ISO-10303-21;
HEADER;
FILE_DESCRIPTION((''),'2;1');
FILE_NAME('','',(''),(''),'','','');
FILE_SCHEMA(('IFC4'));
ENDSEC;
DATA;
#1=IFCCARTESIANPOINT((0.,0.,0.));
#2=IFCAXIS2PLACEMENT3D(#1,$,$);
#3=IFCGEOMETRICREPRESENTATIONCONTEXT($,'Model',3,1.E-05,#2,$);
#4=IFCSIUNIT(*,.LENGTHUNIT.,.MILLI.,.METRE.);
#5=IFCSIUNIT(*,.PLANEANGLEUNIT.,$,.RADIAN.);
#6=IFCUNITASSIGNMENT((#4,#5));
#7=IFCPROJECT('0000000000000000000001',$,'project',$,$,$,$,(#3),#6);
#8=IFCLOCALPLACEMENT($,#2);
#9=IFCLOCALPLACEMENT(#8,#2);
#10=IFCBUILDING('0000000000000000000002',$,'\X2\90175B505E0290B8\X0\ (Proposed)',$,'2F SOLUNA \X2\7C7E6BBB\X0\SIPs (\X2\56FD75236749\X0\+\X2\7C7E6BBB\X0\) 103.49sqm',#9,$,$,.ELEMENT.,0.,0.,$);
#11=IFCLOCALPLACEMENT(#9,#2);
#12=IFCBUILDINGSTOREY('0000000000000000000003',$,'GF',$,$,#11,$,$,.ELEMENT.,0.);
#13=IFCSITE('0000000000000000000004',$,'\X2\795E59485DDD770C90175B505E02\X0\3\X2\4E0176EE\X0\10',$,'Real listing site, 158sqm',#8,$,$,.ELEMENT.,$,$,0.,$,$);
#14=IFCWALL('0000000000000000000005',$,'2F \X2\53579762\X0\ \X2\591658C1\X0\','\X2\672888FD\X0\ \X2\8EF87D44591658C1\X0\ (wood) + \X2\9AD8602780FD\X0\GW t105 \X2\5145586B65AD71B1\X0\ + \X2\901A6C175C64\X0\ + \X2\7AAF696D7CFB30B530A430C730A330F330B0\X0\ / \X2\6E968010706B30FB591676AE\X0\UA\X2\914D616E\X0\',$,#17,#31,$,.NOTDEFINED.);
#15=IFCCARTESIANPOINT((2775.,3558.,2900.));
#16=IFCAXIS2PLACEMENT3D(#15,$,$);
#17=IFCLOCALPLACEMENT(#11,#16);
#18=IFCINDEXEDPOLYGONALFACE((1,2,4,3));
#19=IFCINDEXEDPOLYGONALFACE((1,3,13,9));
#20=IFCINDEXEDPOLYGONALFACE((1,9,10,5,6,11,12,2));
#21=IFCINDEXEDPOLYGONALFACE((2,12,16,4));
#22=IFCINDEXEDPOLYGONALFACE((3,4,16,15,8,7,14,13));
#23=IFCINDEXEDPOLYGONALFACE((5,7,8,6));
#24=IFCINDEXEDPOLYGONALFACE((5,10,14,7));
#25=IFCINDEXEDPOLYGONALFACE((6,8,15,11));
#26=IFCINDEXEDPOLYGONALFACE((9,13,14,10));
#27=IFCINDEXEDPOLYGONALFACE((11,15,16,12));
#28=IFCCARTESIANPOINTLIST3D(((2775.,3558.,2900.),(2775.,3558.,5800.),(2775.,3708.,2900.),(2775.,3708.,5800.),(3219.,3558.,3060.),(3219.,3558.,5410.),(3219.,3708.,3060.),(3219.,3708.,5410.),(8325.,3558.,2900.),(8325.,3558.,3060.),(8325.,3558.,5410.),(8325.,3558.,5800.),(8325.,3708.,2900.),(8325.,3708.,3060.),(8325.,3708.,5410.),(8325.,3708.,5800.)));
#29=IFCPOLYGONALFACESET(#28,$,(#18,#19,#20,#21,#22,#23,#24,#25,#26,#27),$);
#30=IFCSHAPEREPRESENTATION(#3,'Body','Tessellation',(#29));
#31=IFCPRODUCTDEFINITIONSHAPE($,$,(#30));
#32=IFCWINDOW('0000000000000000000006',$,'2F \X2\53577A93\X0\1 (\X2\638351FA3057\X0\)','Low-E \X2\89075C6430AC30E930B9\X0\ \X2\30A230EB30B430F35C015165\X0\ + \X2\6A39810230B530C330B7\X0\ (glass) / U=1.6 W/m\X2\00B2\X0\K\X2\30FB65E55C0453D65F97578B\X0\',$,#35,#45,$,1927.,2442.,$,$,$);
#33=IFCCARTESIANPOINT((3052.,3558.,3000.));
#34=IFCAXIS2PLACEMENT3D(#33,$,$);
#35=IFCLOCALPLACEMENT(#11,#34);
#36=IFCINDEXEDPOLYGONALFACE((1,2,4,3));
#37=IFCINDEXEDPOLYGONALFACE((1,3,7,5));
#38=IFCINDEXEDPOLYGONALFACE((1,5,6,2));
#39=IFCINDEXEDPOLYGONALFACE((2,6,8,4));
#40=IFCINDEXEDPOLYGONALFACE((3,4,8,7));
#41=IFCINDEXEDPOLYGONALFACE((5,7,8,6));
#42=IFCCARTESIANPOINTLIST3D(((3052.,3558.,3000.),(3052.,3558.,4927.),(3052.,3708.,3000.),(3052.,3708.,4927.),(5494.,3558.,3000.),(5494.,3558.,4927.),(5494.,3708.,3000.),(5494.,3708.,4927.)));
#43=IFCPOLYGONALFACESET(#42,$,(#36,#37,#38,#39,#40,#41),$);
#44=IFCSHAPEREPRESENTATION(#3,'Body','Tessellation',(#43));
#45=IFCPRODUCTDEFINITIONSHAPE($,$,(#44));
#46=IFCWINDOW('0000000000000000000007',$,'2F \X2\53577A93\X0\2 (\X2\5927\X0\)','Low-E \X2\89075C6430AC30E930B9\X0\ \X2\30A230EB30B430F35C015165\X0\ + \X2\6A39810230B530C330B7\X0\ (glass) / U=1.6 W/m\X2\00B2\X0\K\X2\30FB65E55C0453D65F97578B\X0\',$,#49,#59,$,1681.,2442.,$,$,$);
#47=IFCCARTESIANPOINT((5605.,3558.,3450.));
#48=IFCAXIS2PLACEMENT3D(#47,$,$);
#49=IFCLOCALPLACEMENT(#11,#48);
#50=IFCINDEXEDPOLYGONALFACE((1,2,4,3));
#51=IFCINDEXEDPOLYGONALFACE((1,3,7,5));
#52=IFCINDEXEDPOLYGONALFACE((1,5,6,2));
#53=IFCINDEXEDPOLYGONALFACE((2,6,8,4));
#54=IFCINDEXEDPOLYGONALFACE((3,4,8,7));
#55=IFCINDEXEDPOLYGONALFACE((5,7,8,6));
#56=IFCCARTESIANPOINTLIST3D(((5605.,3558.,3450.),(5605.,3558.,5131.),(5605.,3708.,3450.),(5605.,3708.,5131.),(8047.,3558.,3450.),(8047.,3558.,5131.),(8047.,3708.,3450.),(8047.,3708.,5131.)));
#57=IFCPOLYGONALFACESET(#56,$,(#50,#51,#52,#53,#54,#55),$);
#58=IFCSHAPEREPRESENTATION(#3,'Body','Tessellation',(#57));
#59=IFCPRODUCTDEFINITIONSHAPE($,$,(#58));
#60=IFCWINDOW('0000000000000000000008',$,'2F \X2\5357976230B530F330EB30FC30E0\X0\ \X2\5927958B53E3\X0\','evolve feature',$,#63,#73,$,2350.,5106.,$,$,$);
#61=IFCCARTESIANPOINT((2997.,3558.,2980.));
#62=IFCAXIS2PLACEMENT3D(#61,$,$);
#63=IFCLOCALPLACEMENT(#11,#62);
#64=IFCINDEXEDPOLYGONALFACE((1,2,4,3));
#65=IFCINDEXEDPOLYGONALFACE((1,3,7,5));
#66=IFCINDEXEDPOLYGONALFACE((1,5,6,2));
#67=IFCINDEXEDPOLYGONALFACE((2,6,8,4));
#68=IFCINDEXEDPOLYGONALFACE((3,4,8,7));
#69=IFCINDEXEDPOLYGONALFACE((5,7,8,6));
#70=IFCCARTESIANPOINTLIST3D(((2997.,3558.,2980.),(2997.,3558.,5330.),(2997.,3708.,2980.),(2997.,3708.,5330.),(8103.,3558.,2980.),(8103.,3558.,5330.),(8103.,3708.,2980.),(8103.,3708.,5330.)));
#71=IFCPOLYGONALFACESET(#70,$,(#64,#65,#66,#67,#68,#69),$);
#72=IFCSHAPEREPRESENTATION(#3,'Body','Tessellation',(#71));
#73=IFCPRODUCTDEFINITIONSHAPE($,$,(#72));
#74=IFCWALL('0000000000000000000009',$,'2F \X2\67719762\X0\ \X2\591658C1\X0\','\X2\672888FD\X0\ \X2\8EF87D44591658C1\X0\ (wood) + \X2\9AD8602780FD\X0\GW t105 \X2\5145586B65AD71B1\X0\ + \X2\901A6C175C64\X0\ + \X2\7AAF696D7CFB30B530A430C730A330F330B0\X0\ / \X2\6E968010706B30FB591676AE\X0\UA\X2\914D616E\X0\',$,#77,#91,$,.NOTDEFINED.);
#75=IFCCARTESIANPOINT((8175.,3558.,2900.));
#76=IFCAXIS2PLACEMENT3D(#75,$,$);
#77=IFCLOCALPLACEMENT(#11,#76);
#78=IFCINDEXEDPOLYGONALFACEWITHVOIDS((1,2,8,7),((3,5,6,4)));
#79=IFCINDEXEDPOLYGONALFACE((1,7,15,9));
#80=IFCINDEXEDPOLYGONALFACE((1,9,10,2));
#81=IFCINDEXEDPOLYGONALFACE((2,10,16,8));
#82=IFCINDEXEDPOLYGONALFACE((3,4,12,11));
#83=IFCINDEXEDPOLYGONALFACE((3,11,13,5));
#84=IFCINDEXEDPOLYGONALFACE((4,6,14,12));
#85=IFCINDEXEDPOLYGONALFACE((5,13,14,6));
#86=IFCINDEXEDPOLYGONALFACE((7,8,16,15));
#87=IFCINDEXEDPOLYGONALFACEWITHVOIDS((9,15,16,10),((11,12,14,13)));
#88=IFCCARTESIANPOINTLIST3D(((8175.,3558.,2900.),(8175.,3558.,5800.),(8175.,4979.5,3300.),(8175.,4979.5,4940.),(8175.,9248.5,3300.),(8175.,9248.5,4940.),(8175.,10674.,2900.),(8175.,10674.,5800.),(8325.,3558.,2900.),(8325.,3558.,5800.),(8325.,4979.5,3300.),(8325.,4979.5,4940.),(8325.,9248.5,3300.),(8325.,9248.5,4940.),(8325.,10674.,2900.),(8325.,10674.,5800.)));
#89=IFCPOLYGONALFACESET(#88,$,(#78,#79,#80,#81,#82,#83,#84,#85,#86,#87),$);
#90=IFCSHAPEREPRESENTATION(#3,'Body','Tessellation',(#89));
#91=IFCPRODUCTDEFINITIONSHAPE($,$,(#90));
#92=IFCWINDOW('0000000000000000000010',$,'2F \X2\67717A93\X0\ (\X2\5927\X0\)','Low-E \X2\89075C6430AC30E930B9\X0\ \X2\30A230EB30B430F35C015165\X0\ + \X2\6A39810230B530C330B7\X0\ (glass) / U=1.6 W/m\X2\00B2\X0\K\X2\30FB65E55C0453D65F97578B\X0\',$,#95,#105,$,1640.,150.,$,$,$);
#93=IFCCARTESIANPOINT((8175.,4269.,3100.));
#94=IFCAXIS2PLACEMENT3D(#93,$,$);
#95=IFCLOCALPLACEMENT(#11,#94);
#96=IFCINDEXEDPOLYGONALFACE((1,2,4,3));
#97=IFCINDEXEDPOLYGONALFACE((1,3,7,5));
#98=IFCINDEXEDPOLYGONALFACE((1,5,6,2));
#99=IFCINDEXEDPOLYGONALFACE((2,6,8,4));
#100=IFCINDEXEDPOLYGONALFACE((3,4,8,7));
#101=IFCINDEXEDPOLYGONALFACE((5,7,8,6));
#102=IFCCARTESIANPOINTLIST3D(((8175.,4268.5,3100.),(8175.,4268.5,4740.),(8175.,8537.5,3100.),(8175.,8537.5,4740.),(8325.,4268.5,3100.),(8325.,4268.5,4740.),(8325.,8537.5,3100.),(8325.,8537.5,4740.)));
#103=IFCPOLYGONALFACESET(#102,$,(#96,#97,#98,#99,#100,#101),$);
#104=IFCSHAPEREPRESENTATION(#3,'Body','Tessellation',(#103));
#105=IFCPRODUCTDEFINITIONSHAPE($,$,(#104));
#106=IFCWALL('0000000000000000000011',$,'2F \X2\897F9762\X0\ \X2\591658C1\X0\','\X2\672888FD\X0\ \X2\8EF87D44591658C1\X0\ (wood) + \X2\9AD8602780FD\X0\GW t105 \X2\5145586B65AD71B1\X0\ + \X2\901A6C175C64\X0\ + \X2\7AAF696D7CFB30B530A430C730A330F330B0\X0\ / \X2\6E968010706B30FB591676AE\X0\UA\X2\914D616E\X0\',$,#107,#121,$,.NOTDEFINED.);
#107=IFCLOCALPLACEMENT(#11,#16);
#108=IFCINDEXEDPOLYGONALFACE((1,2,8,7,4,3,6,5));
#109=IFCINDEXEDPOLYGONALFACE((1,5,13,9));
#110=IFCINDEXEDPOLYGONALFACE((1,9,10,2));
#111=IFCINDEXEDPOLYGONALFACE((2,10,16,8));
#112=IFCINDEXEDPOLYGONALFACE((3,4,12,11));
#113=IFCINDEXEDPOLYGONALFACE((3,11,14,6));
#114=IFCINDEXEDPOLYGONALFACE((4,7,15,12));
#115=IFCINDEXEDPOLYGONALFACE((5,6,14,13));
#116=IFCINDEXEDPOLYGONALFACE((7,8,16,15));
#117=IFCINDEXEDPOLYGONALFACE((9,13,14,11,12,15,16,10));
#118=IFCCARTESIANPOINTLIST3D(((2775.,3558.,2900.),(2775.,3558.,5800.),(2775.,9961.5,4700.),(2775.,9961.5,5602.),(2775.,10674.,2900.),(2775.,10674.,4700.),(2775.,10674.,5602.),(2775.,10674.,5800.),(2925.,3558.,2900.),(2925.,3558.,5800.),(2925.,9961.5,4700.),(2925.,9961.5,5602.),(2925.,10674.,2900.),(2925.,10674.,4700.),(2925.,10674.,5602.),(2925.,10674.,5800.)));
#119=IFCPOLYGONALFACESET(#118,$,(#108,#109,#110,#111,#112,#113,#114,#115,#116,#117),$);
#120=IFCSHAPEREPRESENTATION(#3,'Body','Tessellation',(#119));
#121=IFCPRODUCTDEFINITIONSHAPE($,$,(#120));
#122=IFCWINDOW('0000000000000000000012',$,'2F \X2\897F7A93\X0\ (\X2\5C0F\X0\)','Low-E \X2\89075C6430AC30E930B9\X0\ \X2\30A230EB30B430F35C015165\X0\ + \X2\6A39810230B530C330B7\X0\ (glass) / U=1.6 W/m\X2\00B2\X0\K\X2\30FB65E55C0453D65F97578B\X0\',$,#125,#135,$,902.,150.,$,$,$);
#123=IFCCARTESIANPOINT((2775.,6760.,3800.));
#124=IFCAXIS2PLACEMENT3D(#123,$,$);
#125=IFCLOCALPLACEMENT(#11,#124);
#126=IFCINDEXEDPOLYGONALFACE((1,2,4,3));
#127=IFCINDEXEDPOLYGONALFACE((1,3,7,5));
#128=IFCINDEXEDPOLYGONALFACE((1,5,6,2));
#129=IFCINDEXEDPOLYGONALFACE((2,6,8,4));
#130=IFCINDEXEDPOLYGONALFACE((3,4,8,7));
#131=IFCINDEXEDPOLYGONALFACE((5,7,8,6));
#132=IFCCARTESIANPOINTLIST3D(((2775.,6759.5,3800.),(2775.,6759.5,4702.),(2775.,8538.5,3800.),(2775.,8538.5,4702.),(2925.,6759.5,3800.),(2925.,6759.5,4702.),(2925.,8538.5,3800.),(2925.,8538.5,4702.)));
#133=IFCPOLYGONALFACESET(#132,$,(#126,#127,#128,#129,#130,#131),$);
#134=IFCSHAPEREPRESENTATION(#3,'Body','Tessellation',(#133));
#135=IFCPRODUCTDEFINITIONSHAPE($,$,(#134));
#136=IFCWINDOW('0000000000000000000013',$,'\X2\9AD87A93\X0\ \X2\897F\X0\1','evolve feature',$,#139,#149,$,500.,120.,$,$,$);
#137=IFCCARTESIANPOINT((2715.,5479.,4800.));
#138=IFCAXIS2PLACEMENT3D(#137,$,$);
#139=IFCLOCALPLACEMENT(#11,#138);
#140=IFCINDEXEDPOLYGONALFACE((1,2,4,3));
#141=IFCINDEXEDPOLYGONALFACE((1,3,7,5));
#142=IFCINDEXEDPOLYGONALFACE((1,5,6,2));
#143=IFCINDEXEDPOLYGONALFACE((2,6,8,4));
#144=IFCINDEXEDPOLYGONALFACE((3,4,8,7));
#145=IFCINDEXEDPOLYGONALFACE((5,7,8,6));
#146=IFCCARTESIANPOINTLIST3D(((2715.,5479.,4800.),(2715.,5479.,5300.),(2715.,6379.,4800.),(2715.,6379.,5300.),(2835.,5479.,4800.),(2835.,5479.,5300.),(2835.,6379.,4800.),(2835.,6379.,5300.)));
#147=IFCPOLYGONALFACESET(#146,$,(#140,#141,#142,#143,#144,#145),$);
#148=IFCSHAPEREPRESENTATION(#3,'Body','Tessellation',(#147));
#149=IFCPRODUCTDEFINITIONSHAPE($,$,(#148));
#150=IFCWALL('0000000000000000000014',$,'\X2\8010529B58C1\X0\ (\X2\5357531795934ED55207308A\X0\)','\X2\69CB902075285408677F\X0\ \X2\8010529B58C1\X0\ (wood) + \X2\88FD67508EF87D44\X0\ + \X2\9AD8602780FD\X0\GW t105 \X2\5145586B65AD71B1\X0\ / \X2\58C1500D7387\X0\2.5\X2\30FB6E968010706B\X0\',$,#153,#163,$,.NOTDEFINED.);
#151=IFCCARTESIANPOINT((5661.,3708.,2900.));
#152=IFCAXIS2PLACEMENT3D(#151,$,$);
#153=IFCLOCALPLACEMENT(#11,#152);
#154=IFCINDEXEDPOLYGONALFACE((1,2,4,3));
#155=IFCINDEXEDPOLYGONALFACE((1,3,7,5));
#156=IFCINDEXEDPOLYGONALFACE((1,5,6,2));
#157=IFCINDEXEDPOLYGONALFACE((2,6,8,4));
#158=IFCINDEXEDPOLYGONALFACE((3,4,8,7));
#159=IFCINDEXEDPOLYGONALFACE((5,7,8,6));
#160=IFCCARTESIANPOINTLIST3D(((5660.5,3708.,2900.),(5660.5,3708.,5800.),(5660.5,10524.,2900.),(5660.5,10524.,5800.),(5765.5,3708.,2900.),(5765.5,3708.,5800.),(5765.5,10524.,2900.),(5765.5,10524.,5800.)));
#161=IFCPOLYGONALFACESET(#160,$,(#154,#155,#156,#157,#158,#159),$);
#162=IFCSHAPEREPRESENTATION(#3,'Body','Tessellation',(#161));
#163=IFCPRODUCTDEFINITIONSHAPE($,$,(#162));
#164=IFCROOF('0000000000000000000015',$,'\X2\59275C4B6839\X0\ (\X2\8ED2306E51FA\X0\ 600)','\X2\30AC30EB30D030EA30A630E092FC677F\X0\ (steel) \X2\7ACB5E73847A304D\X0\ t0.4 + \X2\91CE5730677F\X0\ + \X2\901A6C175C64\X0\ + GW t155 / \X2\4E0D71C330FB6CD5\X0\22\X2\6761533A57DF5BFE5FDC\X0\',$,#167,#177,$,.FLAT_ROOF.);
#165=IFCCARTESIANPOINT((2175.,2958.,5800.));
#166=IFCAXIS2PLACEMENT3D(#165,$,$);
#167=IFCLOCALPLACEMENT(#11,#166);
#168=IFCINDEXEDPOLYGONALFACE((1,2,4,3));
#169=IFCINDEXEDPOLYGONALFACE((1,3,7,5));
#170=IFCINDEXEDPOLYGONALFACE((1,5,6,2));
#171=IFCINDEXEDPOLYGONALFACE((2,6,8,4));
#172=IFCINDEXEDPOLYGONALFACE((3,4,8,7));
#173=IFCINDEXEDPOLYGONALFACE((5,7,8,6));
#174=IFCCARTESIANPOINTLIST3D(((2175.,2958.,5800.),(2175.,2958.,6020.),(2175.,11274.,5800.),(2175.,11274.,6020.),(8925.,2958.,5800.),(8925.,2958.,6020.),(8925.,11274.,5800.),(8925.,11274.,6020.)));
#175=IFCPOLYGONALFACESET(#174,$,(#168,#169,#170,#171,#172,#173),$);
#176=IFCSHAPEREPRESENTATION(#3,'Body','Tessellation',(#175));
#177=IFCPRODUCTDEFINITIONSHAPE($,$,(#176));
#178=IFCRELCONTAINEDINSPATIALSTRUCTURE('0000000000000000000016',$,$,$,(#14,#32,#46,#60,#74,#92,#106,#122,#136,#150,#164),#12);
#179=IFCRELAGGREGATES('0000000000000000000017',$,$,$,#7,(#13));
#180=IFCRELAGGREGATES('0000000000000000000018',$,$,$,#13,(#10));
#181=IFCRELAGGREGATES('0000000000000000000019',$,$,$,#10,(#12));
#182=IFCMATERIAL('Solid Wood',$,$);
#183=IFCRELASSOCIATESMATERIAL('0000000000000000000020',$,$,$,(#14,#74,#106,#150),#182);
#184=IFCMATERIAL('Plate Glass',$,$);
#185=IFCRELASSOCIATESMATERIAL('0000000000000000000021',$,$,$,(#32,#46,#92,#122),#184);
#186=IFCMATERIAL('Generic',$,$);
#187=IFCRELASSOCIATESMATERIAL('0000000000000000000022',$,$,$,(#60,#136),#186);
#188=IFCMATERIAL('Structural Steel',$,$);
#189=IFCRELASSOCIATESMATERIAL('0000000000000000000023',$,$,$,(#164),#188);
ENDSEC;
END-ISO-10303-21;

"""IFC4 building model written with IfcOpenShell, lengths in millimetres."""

from ifc_helpers import new_model, si_unit, frame, frame_2d, origin, place, context, project, spatial, rectangle, extrude, material, element, fill, save


model = new_model("IFC4")

# Units and contexts
model_context = context("Model", 3, precision=1e-05, world=origin())
ifc_project = project(units=[si_unit("LENGTHUNIT", "METRE", prefix="MILLI"), si_unit("PLANEANGLEUNIT", "RADIAN")], contexts=[model_context])

# Site, building, storey
site_placement = place(None, origin())
site = spatial("IfcSite", under=ifc_project, at=site_placement, Name="神奈川県逗子市3丁目10", ObjectType="Real listing site, 158sqm", CompositionType="ELEMENT", RefElevation=0.0)
building_placement = place(site_placement, origin())
building = spatial("IfcBuilding", under=site, at=building_placement, Name="逗子市邸 (Proposed)", ObjectType="2F SOLUNA 籾殻SIPs (国産杉+籾殻) 103.49sqm", CompositionType="ELEMENT", ElevationOfRefHeight=0.0, ElevationOfTerrain=0.0)
storey_placement = place(building_placement, origin())
storey = spatial("IfcBuildingStorey", under=building, at=storey_placement, Name="GF", CompositionType="ELEMENT", Elevation=0.0)

# Shared definitions
ifc_material_1 = material(Name="Solid Wood")

# Wall, openings, windows
wall_1_placement = place(storey_placement, frame((2775.0, 3558.0, 2900.0)))
wall_1 = element("IfcWall", 1, at=wall_1_placement, inside=storey, material=ifc_material_1, Name="2F 南面 外壁", Description="木製 軸組外壁 (wood) + 高性能GW t105 充填断熱 + 通気層 + 窯業系サイディング / 準耐火・外皮UA配慮", PredefinedType="NOTDEFINED", context=model_context, shape_type="SweptSolid", body=[
    extrude(rectangle(XDim=5550.0, YDim=150.0, at=frame_2d((2775.0, 75.0))), frame((2775.0, 3558.0, 2900.0)), (0.0, 0.0, 1.0), 2900.0),
])
opening_1_placement = place(storey_placement, frame((3052.0, 3558.0, 3000.0)))
opening_1 = element("IfcOpeningElement", 2, at=opening_1_placement, cuts=wall_1, PredefinedType="NOTDEFINED", context=model_context, shape_type="SweptSolid", body=[
    extrude(rectangle(XDim=2442.0, YDim=150.0, at=frame_2d((1221.0, 75.0))), frame((3052.0, 3558.0, 3000.0)), (0.0, 0.0, 1.0), 1927.0),
])
opening_2_placement = place(storey_placement, frame((5605.0, 3558.0, 3450.0)))
opening_2 = element("IfcOpeningElement", 3, at=opening_2_placement, cuts=wall_1, PredefinedType="NOTDEFINED", context=model_context, shape_type="SweptSolid", body=[
    extrude(rectangle(XDim=2442.0, YDim=150.0, at=frame_2d((1221.0, 75.0))), frame((5605.0, 3558.0, 3450.0)), (0.0, 0.0, 1.0), 1681.0),
])
opening_3_placement = place(storey_placement, frame((2997.0, 3558.0, 2980.0)))
opening_3 = element("IfcOpeningElement", 4, at=opening_3_placement, cuts=wall_1, PredefinedType="NOTDEFINED", context=model_context, shape_type="SweptSolid", body=[
    extrude(rectangle(XDim=5106.0, YDim=150.0, at=frame_2d((2553.0, 75.0))), frame((2997.0, 3558.0, 2980.0)), (0.0, 0.0, 1.0), 2350.0),
])
ifc_material_2 = material(Name="Plate Glass")
window_1_placement = place(storey_placement, frame((3052.0, 3558.0, 3000.0)))
window_1 = element("IfcWindow", 5, at=window_1_placement, inside=storey, material=ifc_material_2, Name="2F 南窓1 (掃出し)", Description="Low-E 複層ガラス アルゴン封入 + 樹脂サッシ (glass) / U=1.6 W/m²K・日射取得型", OverallHeight=1927.0, OverallWidth=2442.0, context=model_context, shape_type="SweptSolid", body=[
    extrude(rectangle(XDim=2442.0, YDim=150.0, at=frame_2d((1221.0, 75.0))), frame((3052.0, 3558.0, 3000.0)), (0.0, 0.0, 1.0), 1927.0),
])
fill(opening_1, window_1)
window_2_placement = place(storey_placement, frame((5605.0, 3558.0, 3450.0)))
window_2 = element("IfcWindow", 6, at=window_2_placement, inside=storey, material=ifc_material_2, Name="2F 南窓2 (大)", Description="Low-E 複層ガラス アルゴン封入 + 樹脂サッシ (glass) / U=1.6 W/m²K・日射取得型", OverallHeight=1681.0, OverallWidth=2442.0, context=model_context, shape_type="SweptSolid", body=[
    extrude(rectangle(XDim=2442.0, YDim=150.0, at=frame_2d((1221.0, 75.0))), frame((5605.0, 3558.0, 3450.0)), (0.0, 0.0, 1.0), 1681.0),
])
fill(opening_2, window_2)
ifc_material_3 = material(Name="Generic")
window_3_placement = place(storey_placement, frame((2997.0, 3558.0, 2980.0)))
window_3 = element("IfcWindow", 7, at=window_3_placement, inside=storey, material=ifc_material_3, Name="2F 南面サンルーム 大開口", Description="evolve feature", OverallHeight=2350.0, OverallWidth=5106.0, context=model_context, shape_type="SweptSolid", body=[
    extrude(rectangle(XDim=5106.0, YDim=150.0, at=frame_2d((2553.0, 75.0))), frame((2997.0, 3558.0, 2980.0)), (0.0, 0.0, 1.0), 2350.0),
])
fill(opening_3, window_3)

# Wall, opening, window
wall_2_placement = place(storey_placement, frame((8175.0, 3558.0, 2900.0)))
wall_2 = element("IfcWall", 8, at=wall_2_placement, inside=storey, material=ifc_material_1, Name="2F 東面 外壁", Description="木製 軸組外壁 (wood) + 高性能GW t105 充填断熱 + 通気層 + 窯業系サイディング / 準耐火・外皮UA配慮", PredefinedType="NOTDEFINED", context=model_context, shape_type="SweptSolid", body=[
    extrude(rectangle(XDim=150.0, YDim=7116.0, at=frame_2d((75.0, 3558.0))), frame((8175.0, 3558.0, 2900.0)), (0.0, 0.0, 1.0), 2900.0),
])
opening_4_placement = place(storey_placement, frame((8175.0, 4269.0, 3100.0)))
opening_4 = element("IfcOpeningElement", 9, at=opening_4_placement, cuts=wall_2, PredefinedType="NOTDEFINED", context=model_context, shape_type="SweptSolid", body=[
    extrude(rectangle(XDim=150.0, YDim=4269.0, at=frame_2d((75.0, 2134.0))), frame((8175.0, 4269.0, 3100.0)), (0.0, 0.0, 1.0), 1640.0),
])
window_4_placement = place(storey_placement, frame((8175.0, 4269.0, 3100.0)))
window_4 = element("IfcWindow", 10, at=window_4_placement, inside=storey, material=ifc_material_2, Name="2F 東窓 (大)", Description="Low-E 複層ガラス アルゴン封入 + 樹脂サッシ (glass) / U=1.6 W/m²K・日射取得型", OverallHeight=1640.0, OverallWidth=150.0, context=model_context, shape_type="SweptSolid", body=[
    extrude(rectangle(XDim=150.0, YDim=4269.0, at=frame_2d((75.0, 2134.0))), frame((8175.0, 4269.0, 3100.0)), (0.0, 0.0, 1.0), 1640.0),
])
fill(opening_4, window_4)

# Wall, openings, windows
wall_3_placement = place(storey_placement, frame((2775.0, 3558.0, 2900.0)))
wall_3 = element("IfcWall", 11, at=wall_3_placement, inside=storey, material=ifc_material_1, Name="2F 西面 外壁", Description="木製 軸組外壁 (wood) + 高性能GW t105 充填断熱 + 通気層 + 窯業系サイディング / 準耐火・外皮UA配慮", PredefinedType="NOTDEFINED", context=model_context, shape_type="SweptSolid", body=[
    extrude(rectangle(XDim=150.0, YDim=7116.0, at=frame_2d((75.0, 3558.0))), frame((2775.0, 3558.0, 2900.0)), (0.0, 0.0, 1.0), 2900.0),
])
opening_5_placement = place(storey_placement, frame((2775.0, 6760.0, 3800.0)))
opening_5 = element("IfcOpeningElement", 12, at=opening_5_placement, cuts=wall_3, PredefinedType="NOTDEFINED", context=model_context, shape_type="SweptSolid", body=[
    extrude(rectangle(XDim=150.0, YDim=1779.0, at=frame_2d((75.0, 889.0))), frame((2775.0, 6760.0, 3800.0)), (0.0, 0.0, 1.0), 902.0),
])
opening_6_placement = place(storey_placement, frame((2715.0, 5479.0, 4800.0)))
opening_6 = element("IfcOpeningElement", 13, at=opening_6_placement, cuts=wall_3, PredefinedType="NOTDEFINED", context=model_context, shape_type="SweptSolid", body=[
    extrude(rectangle(XDim=120.0, YDim=900.0, at=frame_2d((60.0, 450.0))), frame((2715.0, 5479.0, 4800.0)), (0.0, 0.0, 1.0), 500.0),
])
window_5_placement = place(storey_placement, frame((2775.0, 6760.0, 3800.0)))
window_5 = element("IfcWindow", 14, at=window_5_placement, inside=storey, material=ifc_material_2, Name="2F 西窓 (小)", Description="Low-E 複層ガラス アルゴン封入 + 樹脂サッシ (glass) / U=1.6 W/m²K・日射取得型", OverallHeight=902.0, OverallWidth=150.0, context=model_context, shape_type="SweptSolid", body=[
    extrude(rectangle(XDim=150.0, YDim=1779.0, at=frame_2d((75.0, 889.0))), frame((2775.0, 6760.0, 3800.0)), (0.0, 0.0, 1.0), 902.0),
])
fill(opening_5, window_5)
window_6_placement = place(storey_placement, frame((2715.0, 5479.0, 4800.0)))
window_6 = element("IfcWindow", 15, at=window_6_placement, inside=storey, material=ifc_material_3, Name="高窓 西1", Description="evolve feature", OverallHeight=500.0, OverallWidth=120.0, context=model_context, shape_type="SweptSolid", body=[
    extrude(rectangle(XDim=120.0, YDim=900.0, at=frame_2d((60.0, 450.0))), frame((2715.0, 5479.0, 4800.0)), (0.0, 0.0, 1.0), 500.0),
])
fill(opening_6, window_6)

# Wall
wall_4_placement = place(storey_placement, frame((5661.0, 3708.0, 2900.0)))
element("IfcWall", 16, at=wall_4_placement, inside=storey, material=ifc_material_1, Name="耐力壁 (南北間仕切り)", Description="構造用合板 耐力壁 (wood) + 製材軸組 + 高性能GW t105 充填断熱 / 壁倍率2.5・準耐火", PredefinedType="NOTDEFINED", context=model_context, shape_type="SweptSolid", body=[
    extrude(rectangle(XDim=105.0, YDim=6816.0, at=frame_2d((52.0, 3408.0))), frame((5661.0, 3708.0, 2900.0)), (0.0, 0.0, 1.0), 2900.0),
])

# Roof
ifc_material_4 = material(Name="Structural Steel")
roof_1_placement = place(storey_placement, frame((2175.0, 2958.0, 5800.0)))
element("IfcRoof", 17, at=roof_1_placement, inside=storey, material=ifc_material_4, Name="大屋根 (軒の出 600)", Description="ガルバリウム鋼板 (steel) 立平葺き t0.4 + 野地板 + 通気層 + GW t155 / 不燃・法22条区域対応", PredefinedType="FLAT_ROOF", context=model_context, shape_type="SweptSolid", body=[
    extrude(rectangle(XDim=6750.0, YDim=8316.0, at=frame_2d((3375.0, 4158.0))), frame((2175.0, 2958.0, 5800.0)), (0.0, 0.0, 1.0), 220.0),
])

save(model, "model.ifc")
